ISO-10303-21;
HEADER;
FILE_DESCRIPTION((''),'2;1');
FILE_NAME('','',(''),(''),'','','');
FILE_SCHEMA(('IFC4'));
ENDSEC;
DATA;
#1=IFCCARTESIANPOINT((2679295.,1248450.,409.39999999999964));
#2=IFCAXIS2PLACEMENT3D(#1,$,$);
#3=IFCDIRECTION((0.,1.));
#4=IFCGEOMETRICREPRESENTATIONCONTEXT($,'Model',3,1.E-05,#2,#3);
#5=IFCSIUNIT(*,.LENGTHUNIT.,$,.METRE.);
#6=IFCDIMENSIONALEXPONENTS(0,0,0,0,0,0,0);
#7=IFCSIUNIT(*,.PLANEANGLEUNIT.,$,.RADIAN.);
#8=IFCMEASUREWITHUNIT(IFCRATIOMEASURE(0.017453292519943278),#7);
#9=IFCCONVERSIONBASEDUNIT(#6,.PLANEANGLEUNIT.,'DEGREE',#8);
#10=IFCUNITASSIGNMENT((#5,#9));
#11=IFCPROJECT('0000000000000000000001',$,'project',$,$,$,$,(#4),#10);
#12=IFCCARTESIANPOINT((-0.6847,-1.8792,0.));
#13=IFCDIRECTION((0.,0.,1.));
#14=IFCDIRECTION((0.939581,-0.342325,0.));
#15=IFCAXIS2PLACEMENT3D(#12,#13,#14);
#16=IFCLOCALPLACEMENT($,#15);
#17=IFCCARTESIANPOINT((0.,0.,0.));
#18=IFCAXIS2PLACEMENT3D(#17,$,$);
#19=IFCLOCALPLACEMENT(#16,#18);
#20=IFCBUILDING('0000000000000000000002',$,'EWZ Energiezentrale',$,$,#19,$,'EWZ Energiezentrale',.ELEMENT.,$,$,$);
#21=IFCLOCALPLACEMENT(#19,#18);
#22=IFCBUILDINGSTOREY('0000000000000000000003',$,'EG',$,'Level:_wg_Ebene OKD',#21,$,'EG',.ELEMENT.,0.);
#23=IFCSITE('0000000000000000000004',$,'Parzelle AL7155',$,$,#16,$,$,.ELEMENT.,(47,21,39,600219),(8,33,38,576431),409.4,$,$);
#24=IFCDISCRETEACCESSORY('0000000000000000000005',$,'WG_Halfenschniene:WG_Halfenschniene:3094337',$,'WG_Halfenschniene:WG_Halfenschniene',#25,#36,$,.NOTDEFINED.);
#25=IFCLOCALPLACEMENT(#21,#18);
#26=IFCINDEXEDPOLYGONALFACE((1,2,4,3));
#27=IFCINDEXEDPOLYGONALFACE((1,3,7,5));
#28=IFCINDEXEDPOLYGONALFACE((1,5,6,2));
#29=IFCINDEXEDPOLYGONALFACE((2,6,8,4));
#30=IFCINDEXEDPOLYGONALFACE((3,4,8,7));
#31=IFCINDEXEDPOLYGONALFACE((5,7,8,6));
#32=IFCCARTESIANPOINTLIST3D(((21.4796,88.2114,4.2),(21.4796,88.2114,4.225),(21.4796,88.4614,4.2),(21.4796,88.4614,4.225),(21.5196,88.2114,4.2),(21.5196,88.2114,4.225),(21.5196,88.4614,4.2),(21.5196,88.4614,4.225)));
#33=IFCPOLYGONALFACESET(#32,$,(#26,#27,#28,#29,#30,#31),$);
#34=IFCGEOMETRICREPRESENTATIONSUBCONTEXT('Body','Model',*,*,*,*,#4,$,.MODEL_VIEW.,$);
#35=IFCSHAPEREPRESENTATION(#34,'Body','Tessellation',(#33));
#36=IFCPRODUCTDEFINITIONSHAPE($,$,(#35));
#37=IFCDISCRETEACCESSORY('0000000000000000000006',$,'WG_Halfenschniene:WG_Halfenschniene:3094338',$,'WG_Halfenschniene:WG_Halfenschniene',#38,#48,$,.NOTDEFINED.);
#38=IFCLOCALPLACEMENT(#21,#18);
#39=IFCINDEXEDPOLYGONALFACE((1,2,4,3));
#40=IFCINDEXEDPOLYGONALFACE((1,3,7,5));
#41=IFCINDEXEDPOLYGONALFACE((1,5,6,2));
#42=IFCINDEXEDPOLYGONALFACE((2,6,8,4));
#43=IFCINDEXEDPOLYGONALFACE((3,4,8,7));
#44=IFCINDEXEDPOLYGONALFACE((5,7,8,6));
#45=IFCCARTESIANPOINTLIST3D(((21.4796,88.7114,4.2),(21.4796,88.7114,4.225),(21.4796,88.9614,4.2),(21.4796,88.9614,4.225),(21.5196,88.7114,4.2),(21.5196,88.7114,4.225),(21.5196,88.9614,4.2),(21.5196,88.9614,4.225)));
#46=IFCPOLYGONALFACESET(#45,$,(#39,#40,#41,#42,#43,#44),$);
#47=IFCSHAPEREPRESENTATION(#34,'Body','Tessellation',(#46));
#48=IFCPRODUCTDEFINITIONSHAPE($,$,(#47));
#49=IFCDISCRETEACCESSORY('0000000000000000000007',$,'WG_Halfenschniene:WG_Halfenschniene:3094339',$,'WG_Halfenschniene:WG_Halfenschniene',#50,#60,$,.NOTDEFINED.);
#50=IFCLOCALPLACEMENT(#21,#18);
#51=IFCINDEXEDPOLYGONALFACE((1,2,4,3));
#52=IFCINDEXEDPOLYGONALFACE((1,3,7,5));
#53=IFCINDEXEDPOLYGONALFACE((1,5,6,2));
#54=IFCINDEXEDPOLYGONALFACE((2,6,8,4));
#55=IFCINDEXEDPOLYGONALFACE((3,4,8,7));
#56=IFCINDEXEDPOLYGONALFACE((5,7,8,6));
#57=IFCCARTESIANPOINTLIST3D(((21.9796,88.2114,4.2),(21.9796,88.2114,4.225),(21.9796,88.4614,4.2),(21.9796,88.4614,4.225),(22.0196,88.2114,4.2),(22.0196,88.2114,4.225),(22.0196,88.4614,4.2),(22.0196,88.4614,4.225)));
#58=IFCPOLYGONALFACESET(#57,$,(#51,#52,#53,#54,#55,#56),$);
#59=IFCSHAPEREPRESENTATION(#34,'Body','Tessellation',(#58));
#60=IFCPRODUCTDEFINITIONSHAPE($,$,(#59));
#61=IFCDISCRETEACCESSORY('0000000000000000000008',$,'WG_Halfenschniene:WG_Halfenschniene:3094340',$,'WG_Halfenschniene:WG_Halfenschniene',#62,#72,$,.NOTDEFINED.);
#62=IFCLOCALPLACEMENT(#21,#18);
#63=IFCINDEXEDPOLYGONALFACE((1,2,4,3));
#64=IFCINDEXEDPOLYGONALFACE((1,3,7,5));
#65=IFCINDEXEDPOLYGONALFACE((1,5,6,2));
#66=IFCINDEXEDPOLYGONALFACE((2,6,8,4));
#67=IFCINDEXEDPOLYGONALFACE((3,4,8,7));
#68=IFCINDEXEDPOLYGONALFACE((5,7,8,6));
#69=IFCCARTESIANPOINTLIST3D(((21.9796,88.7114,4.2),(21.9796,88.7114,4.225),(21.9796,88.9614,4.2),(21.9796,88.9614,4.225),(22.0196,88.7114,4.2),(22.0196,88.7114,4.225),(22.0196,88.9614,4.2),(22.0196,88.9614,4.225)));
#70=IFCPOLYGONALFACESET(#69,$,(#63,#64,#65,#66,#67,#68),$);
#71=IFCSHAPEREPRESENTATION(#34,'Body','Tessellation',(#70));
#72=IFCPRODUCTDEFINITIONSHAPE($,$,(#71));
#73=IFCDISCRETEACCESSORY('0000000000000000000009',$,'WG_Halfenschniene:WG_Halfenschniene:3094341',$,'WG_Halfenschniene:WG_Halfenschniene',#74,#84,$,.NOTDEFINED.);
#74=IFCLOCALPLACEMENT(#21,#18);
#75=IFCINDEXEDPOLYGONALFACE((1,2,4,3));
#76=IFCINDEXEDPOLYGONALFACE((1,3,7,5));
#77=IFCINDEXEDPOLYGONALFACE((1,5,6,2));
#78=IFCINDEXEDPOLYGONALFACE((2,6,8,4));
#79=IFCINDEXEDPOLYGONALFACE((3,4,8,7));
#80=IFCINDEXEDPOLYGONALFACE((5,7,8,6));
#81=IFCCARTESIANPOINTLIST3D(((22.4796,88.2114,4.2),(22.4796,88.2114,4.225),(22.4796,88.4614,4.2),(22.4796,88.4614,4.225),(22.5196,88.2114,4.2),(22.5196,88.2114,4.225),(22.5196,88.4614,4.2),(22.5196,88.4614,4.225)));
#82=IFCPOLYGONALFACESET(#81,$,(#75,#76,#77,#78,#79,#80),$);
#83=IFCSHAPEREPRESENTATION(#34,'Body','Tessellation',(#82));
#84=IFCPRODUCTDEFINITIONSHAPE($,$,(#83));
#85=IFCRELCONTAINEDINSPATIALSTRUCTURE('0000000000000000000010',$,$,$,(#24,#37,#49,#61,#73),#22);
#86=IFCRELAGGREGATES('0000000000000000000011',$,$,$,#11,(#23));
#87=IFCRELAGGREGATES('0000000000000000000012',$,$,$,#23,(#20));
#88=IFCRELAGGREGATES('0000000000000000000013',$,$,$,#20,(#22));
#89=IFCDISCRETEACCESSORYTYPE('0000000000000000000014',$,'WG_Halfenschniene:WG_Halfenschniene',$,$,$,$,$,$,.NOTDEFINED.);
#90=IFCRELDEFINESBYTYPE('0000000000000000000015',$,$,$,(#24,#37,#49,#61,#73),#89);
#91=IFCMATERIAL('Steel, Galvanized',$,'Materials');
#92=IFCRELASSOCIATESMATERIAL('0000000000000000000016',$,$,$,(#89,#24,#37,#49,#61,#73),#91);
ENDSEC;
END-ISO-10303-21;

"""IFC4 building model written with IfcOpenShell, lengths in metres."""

from ifc_helpers import new_model, entity, si_unit, converted_unit, direction, frame, origin, place, context, subcontext, project, spatial, indexed_curve, outline, extrude, source, transform, mapped, material, type_object, element, save


model = new_model("IFC4")

# Units and contexts
model_context = context("Model", 3, precision=1e-05, world=frame((2679295.0, 1248450.0, 409.39999999999964)), true_north=direction((0.0, 1.0)))
body_context = subcontext(model_context, "Body", "Model", "MODEL_VIEW")
ifc_project = project(units=[si_unit("LENGTHUNIT", "METRE"), converted_unit("PLANEANGLEUNIT", "DEGREE", entity("IfcRatioMeasure", 0.017453292519943278), si_unit("PLANEANGLEUNIT", "RADIAN"), dimensions=[0, 0, 0, 0, 0, 0, 0])], contexts=[model_context])

# Site, building, storey
site_placement = place(None, frame((-0.6847, -1.8792, 0.0), z_axis=(0.0, 0.0, 1.0), x_axis=(0.939581, -0.342325, 0.0)))
site = spatial("IfcSite", under=ifc_project, at=site_placement, Name="Parzelle AL7155", CompositionType="ELEMENT", RefLatitude=(47, 21, 39, 600219), RefLongitude=(8, 33, 38, 576431), RefElevation=409.4)
building_placement = place(site_placement, origin())
building = spatial("IfcBuilding", under=site, at=building_placement, Name="EWZ Energiezentrale", LongName="EWZ Energiezentrale", CompositionType="ELEMENT")
storey_placement = place(building_placement, origin())
storey = spatial("IfcBuildingStorey", under=building, at=storey_placement, Name="EG", ObjectType="Level:_wg_Ebene OKD", LongName="EG", CompositionType="ELEMENT", Elevation=0.0)

# Discrete accessories
ifc_material_1 = material(Name="Steel, Galvanized", Category="Materials")
discrete_accessory_type = type_object("IfcDiscreteAccessoryType", Name="WG_Halfenschniene:WG_Halfenschniene", PredefinedType="NOTDEFINED", material=ifc_material_1)
shared_shape_1 = source(origin(), body_context, "Body", "SweptSolid", [
    extrude(outline(indexed_curve([(-0.125, -0.02), (0.125, -0.02), (0.125, 0.02), (-0.125, 0.02), (-0.125, -0.02)], self_intersect=False)), frame((0.125, 0.0, -0.0125)), (0.0, 0.0, 1.0), 0.025),
])
for number, where, z_axis, x_axis, name in (
    (1, (21.4996, 88.2114, 4.2125), (0.0, 0.0, -1.0), (0.0, 1.0, 0.0), "WG_Halfenschniene:WG_Halfenschniene:3094337"),
    (2, (21.4996, 88.7114, 4.2125), (0.0, 0.0, -1.0), (0.0, 1.0, 0.0), "WG_Halfenschniene:WG_Halfenschniene:3094338"),
    (3, (21.9996, 88.2114, 4.2125), (0.0, 0.0, -1.0), (0.0, 1.0, 0.0), "WG_Halfenschniene:WG_Halfenschniene:3094339"),
    (4, (21.9996, 88.7114, 4.2125), (0.0, 0.0, -1.0), (0.0, 1.0, 0.0), "WG_Halfenschniene:WG_Halfenschniene:3094340"),
    (5, (22.4996, 88.2114, 4.2125), (0.0, 0.0, -1.0), (0.0, 1.0, 0.0), "WG_Halfenschniene:WG_Halfenschniene:3094341"),
):
    element("IfcDiscreteAccessory", number, at=place(storey_placement, frame(where, z_axis=z_axis, x_axis=x_axis)), inside=storey, type_object=discrete_accessory_type, material=ifc_material_1, Name=name, ObjectType="WG_Halfenschniene:WG_Halfenschniene", PredefinedType="NOTDEFINED", context=body_context, shape_type="MappedRepresentation", body=[
        mapped(shared_shape_1, transform((0.0, 0.0, 0.0), scale=1.0)),
    ])

save(model, "model.ifc")
